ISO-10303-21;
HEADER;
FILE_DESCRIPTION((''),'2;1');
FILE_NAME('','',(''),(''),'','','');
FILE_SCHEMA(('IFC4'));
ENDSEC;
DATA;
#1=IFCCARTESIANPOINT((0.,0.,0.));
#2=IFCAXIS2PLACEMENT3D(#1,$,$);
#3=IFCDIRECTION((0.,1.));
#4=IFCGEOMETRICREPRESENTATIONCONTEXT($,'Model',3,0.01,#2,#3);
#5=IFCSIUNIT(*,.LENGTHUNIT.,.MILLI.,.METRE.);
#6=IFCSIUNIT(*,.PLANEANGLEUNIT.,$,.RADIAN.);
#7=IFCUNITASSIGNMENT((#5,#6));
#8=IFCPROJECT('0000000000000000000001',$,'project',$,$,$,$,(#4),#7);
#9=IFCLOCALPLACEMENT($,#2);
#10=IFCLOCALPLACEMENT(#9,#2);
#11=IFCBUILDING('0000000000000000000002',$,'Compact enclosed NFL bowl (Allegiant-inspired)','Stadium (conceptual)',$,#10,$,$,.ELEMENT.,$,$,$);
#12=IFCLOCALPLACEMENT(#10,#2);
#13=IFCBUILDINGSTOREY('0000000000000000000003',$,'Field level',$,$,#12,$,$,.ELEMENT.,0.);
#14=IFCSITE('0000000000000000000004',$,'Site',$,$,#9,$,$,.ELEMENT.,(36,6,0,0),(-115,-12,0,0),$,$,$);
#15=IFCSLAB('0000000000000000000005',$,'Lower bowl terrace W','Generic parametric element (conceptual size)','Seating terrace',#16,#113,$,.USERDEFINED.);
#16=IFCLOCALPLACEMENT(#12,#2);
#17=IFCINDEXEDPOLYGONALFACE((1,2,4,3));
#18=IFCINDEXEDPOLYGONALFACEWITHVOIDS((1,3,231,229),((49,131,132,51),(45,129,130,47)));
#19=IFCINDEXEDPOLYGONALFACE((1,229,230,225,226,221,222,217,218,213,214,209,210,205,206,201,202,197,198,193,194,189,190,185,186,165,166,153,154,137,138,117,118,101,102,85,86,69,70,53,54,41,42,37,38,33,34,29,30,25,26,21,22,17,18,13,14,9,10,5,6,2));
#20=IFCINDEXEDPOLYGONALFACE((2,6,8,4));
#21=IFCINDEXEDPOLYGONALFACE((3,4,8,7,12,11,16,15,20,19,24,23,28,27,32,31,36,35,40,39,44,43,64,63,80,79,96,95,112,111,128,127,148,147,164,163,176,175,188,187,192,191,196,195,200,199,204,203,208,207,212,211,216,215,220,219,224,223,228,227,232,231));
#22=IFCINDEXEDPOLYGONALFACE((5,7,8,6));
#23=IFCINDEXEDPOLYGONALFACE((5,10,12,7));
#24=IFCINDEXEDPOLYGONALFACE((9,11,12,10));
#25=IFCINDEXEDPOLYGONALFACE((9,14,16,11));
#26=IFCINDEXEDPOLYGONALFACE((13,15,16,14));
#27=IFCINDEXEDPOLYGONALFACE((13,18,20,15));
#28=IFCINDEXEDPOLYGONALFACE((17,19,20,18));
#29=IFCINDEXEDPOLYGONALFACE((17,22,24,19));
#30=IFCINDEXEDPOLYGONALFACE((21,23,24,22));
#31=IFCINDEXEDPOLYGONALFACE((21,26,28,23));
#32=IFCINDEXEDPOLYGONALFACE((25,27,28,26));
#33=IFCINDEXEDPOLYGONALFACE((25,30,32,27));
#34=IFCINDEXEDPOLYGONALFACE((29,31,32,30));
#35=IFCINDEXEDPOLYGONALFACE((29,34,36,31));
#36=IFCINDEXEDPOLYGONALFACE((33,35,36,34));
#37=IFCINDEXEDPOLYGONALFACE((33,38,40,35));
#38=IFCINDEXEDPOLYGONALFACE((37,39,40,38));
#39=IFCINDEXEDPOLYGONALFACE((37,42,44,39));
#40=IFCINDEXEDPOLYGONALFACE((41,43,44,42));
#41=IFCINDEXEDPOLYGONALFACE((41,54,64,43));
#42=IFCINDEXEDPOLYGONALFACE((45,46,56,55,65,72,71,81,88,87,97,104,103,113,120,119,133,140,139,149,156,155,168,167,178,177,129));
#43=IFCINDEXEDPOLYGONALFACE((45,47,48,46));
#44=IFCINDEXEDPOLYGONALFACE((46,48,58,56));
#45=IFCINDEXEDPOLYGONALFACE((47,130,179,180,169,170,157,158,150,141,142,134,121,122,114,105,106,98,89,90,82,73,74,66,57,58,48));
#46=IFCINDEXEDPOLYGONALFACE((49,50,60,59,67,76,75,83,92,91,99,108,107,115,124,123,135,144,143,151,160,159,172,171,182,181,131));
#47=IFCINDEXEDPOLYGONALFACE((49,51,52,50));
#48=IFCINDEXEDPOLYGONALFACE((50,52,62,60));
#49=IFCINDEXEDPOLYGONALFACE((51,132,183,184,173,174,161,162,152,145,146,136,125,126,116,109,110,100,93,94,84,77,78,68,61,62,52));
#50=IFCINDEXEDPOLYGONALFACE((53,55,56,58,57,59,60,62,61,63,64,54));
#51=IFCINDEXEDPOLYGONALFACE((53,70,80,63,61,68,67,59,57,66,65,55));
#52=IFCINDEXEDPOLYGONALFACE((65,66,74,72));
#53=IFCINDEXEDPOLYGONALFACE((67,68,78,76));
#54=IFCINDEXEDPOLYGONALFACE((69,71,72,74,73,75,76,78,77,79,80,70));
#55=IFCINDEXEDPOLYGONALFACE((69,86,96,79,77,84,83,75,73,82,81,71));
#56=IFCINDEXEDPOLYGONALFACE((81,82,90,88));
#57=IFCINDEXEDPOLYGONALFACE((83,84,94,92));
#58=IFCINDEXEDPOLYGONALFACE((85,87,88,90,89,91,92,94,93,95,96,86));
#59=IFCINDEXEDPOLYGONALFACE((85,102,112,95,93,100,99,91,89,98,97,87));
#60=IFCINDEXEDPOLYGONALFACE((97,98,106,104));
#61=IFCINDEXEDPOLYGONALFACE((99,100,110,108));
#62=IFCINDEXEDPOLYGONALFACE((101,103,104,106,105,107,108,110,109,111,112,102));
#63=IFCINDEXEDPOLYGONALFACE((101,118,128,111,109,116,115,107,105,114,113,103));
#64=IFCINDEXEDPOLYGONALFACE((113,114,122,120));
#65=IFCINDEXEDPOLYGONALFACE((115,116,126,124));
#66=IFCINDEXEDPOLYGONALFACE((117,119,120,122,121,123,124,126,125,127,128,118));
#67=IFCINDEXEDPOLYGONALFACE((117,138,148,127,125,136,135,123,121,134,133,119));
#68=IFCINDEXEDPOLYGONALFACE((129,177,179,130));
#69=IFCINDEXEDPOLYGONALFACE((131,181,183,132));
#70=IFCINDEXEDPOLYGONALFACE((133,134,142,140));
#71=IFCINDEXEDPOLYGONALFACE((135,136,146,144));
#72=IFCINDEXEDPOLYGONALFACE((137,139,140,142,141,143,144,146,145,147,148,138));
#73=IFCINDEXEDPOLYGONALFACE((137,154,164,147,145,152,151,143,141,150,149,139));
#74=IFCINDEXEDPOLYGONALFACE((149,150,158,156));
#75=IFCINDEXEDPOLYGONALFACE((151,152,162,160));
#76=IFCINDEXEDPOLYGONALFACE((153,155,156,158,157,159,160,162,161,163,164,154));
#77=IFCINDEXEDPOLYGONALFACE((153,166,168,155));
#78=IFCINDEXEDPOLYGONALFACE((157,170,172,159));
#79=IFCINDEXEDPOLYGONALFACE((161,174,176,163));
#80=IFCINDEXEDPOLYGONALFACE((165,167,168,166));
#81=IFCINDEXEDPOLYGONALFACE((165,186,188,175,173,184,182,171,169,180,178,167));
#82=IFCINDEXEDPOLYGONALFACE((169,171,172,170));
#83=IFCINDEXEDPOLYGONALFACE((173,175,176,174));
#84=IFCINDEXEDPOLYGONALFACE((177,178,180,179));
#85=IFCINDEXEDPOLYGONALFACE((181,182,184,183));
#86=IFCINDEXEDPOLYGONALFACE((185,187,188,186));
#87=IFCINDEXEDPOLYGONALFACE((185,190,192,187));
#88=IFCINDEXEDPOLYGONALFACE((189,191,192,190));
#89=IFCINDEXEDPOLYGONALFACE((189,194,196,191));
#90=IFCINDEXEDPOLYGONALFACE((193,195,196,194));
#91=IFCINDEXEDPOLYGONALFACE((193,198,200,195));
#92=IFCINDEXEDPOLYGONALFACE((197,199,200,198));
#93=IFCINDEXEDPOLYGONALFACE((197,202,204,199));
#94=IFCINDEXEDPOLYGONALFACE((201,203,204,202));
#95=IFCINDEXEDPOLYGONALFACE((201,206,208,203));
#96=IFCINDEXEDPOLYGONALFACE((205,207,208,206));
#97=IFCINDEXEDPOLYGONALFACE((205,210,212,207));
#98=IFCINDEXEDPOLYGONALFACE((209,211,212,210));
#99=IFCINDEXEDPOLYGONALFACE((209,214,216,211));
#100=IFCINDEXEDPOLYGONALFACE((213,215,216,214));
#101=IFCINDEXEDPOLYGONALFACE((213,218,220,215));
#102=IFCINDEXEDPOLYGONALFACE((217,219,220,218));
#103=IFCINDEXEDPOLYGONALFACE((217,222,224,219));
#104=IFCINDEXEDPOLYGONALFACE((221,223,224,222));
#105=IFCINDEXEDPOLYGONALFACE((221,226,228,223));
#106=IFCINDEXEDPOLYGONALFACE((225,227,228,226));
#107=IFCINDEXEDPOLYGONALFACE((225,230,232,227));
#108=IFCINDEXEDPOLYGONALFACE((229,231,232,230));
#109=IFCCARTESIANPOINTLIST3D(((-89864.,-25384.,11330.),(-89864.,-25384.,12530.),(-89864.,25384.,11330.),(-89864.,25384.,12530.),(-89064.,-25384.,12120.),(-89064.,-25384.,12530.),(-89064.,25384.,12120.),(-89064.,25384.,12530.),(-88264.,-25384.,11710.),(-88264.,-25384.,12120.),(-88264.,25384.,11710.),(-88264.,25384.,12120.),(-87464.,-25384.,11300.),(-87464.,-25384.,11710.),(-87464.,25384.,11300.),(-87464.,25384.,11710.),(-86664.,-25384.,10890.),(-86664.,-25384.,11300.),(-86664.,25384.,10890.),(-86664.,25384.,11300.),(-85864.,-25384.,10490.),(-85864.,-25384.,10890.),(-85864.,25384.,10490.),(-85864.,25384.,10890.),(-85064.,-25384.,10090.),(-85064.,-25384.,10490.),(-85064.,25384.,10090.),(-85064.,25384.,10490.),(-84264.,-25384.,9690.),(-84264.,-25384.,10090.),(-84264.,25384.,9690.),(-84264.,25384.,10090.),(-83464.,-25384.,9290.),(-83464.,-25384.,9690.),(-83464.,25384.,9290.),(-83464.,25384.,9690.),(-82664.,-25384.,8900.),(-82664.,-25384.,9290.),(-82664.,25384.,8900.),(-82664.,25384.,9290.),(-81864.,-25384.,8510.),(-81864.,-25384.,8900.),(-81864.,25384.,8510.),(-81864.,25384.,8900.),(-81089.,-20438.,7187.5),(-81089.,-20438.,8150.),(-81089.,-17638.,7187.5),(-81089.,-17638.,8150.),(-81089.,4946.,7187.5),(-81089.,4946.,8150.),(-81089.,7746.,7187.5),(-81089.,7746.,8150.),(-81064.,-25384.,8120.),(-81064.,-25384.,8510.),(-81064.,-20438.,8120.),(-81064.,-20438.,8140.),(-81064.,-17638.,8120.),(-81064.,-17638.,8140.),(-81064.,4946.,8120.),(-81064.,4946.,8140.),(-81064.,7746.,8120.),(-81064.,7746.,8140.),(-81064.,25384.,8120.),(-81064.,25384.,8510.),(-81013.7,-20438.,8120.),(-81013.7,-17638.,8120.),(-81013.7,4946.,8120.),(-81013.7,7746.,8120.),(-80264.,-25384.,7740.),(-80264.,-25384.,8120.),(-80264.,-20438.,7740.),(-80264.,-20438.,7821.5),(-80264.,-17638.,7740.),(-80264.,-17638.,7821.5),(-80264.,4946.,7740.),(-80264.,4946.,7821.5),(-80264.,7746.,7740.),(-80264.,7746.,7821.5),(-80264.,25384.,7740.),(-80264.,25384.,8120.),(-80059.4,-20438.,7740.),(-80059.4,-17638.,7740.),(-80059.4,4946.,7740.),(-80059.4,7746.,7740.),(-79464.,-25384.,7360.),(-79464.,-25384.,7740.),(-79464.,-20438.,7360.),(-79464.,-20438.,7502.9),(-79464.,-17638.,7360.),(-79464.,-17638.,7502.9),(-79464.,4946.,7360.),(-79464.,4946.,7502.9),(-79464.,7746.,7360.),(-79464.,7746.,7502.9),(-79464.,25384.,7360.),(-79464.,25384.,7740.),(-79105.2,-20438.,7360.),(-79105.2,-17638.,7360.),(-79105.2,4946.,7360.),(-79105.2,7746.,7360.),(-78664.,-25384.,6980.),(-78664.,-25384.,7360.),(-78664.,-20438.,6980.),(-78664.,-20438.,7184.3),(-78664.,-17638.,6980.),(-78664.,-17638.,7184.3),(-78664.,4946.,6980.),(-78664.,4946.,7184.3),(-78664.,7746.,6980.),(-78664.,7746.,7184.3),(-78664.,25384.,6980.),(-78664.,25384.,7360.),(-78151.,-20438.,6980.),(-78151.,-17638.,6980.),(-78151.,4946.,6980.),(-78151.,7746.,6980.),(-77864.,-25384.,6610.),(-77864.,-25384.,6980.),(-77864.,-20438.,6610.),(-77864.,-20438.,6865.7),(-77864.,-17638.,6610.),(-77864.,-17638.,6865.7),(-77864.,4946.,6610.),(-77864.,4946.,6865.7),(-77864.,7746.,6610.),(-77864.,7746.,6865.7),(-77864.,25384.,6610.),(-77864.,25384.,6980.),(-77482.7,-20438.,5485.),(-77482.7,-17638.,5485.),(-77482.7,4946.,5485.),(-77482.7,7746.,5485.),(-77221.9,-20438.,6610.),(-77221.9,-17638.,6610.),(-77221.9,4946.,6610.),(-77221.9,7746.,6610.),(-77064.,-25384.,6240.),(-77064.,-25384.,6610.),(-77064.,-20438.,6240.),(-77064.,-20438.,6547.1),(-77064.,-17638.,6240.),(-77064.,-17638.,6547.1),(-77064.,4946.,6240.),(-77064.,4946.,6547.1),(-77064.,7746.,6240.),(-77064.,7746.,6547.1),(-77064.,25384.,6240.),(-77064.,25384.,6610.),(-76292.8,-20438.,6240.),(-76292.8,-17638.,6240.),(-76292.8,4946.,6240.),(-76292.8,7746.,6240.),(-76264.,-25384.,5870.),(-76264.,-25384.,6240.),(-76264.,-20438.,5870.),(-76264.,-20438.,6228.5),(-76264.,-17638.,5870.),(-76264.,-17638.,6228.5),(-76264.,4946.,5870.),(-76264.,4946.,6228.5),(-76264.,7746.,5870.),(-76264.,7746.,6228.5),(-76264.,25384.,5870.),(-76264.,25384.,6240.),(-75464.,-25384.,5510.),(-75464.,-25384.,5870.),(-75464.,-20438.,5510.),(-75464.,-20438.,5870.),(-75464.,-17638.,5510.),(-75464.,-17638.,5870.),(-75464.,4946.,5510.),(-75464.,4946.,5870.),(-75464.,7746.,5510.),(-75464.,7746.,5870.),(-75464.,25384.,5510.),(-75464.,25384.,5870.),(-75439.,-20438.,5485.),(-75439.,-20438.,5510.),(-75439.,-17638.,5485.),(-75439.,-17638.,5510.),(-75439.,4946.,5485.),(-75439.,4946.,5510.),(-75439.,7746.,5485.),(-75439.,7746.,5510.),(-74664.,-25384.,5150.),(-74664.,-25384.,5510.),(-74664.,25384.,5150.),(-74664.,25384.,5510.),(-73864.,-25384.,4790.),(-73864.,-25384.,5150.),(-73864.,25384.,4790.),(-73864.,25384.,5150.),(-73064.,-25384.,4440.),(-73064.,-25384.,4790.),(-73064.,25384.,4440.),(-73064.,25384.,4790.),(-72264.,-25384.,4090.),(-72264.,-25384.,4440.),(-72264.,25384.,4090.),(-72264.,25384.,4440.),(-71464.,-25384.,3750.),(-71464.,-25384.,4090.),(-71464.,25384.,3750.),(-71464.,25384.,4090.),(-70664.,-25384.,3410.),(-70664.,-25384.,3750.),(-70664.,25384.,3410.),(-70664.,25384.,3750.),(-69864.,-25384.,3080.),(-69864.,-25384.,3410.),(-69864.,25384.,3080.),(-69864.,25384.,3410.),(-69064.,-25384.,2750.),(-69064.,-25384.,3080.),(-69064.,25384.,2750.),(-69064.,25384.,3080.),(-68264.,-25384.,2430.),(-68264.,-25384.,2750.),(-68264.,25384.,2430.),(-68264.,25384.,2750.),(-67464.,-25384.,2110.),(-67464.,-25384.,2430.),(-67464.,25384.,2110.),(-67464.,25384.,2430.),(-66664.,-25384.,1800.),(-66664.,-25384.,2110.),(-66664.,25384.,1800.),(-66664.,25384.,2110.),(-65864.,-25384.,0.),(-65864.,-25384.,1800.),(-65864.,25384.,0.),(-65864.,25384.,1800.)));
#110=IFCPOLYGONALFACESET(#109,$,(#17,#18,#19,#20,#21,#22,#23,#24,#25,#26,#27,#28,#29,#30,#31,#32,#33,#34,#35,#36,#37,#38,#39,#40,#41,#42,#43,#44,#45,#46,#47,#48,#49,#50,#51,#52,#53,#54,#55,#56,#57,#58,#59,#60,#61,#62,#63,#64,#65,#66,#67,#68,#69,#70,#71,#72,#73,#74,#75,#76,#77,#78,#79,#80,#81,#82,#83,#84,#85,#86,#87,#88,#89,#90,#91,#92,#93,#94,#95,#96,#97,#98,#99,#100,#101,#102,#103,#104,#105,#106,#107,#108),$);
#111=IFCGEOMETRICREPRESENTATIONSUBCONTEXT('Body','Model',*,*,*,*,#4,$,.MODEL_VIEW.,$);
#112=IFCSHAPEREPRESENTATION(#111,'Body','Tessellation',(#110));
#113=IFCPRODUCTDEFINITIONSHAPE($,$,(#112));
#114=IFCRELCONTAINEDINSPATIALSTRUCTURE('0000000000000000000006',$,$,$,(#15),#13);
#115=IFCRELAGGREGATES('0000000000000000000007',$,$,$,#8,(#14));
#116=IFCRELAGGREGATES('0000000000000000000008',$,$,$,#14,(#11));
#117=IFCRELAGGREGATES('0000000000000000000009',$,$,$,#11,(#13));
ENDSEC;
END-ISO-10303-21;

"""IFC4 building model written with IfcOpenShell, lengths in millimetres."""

from ifc_helpers import new_model, si_unit, direction, frame, origin, place, context, subcontext, project, spatial, line, indexed_curve, outline, extrude, element, save


model = new_model("IFC4")

# Units and contexts
model_context = context("Model", 3, precision=0.01, world=origin(), true_north=direction((0.0, 1.0)))
body_context = subcontext(model_context, "Body", "Model", "MODEL_VIEW")
ifc_project = project(units=[si_unit("LENGTHUNIT", "METRE", prefix="MILLI"), si_unit("PLANEANGLEUNIT", "RADIAN")], contexts=[model_context])

# Site, building, storey
site_placement = place(None, origin())
site = spatial("IfcSite", under=ifc_project, at=site_placement, Name="Site", CompositionType="ELEMENT", RefLatitude=(36, 6, 0, 0), RefLongitude=(-115, -12, 0, 0))
building_placement = place(site_placement, origin())
building = spatial("IfcBuilding", under=site, at=building_placement, Name="Compact enclosed NFL bowl (Allegiant-inspired)", Description="Stadium (conceptual)", CompositionType="ELEMENT")
storey_placement = place(building_placement, origin())
storey = spatial("IfcBuildingStorey", under=building, at=storey_placement, Name="Field level", CompositionType="ELEMENT", Elevation=0.0)

# Shared definitions
placement = place(storey_placement, origin())

# Slab, openings
slab_1 = element("IfcSlab", 1, at=placement, inside=storey, Name="Lower bowl terrace W", Description="Generic parametric element (conceptual size)", ObjectType="Seating terrace", PredefinedType="USERDEFINED", context=body_context, shape_type="SweptSolid", body=[
    extrude(outline(indexed_curve([(24000.0, 11330.0), (24000.0, 12530.0), (23200.0, 12530.0), (23200.0, 12120.0), (22400.0, 12120.0), (22400.0, 11710.0), (21600.0, 11710.0), (21600.0, 11300.0), (20800.0, 11300.0), (20800.0, 10890.0), (20000.0, 10890.0), (20000.0, 10490.0), (19200.0, 10490.0), (19200.0, 10090.0), (18400.0, 10090.0), (18400.0, 9690.0), (17600.0, 9690.0), (17600.0, 9290.0), (16800.0, 9290.0), (16800.0, 8900.0), (16000.0, 8900.0), (16000.0, 8510.0), (15200.0, 8510.0), (15200.0, 8120.0), (14400.0, 8120.0), (14400.0, 7740.0), (13600.0, 7740.0), (13600.0, 7360.0), (12800.0, 7360.0), (12800.0, 6980.0), (12000.0, 6980.0), (12000.0, 6610.0), (11200.0, 6610.0), (11200.0, 6240.0), (10400.0, 6240.0), (10400.0, 5870.0), (9600.0, 5870.0), (9600.0, 5510.0), (8800.0, 5510.0), (8800.0, 5150.0), (8000.0, 5150.0), (8000.0, 4790.0), (7200.0, 4790.0), (7200.0, 4440.0), (6400.0, 4440.0), (6400.0, 4090.0), (5600.0, 4090.0), (5600.0, 3750.0), (4800.0, 3750.0), (4800.0, 3410.0), (4000.0, 3410.0), (4000.0, 3080.0), (3200.0, 3080.0), (3200.0, 2750.0), (2400.0, 2750.0), (2400.0, 2430.0), (1600.0, 2430.0), (1600.0, 2110.0), (800.0, 2110.0), (800.0, 1800.0), (0.0, 1800.0), (0.0, 0.0)], segments=[line(1, 2, 3, 4, 5, 6, 7, 8, 9, 10, 11, 12, 13, 14, 15, 16, 17, 18, 19, 20, 21, 22, 23, 24, 25, 26, 27, 28, 29, 30, 31, 32, 33, 34, 35, 36, 37, 38, 39, 40, 41, 42, 43, 44, 45, 46, 47, 48, 49, 50, 51, 52, 53, 54, 55, 56, 57, 58, 59, 60, 61, 62, 1)], self_intersect=False)), frame((-65864.0, -25384.0, 0.0), z_axis=(0.0, 1.0, 0.0), x_axis=(-1.0, 0.0, 0.0)), (0.0, 0.0, 1.0), 50768.0),
])
opening_1_placement = place(placement, origin())
element("IfcOpeningElement", 2, at=opening_1_placement, cuts=slab_1, ObjectType="Vomitory", PredefinedType="OPENING", context=body_context, shape_type="SweptSolid", body=[
    extrude(outline(indexed_curve([(9575.0, 5485.0), (15225.0, 5485.0), (15225.0, 8150.0), (9575.0, 5900.0)], segments=[line(1, 2, 3, 4, 1)], self_intersect=False)), frame((-65864.0, 4946.0, 0.0), z_axis=(0.0, 1.0, 0.0), x_axis=(-1.0, 0.0, 0.0)), (0.0, 0.0, 1.0), 2800.0),
])
opening_2_placement = place(placement, origin())
element("IfcOpeningElement", 3, at=opening_2_placement, cuts=slab_1, ObjectType="Vomitory", PredefinedType="OPENING", context=body_context, shape_type="SweptSolid", body=[
    extrude(outline(indexed_curve([(9575.0, 5485.0), (15225.0, 5485.0), (15225.0, 8150.0), (9575.0, 5900.0)], segments=[line(1, 2, 3, 4, 1)], self_intersect=False)), frame((-65864.0, -20438.0, 0.0), z_axis=(0.0, 1.0, 0.0), x_axis=(-1.0, 0.0, 0.0)), (0.0, 0.0, 1.0), 2800.0),
])

save(model, "model.ifc")
